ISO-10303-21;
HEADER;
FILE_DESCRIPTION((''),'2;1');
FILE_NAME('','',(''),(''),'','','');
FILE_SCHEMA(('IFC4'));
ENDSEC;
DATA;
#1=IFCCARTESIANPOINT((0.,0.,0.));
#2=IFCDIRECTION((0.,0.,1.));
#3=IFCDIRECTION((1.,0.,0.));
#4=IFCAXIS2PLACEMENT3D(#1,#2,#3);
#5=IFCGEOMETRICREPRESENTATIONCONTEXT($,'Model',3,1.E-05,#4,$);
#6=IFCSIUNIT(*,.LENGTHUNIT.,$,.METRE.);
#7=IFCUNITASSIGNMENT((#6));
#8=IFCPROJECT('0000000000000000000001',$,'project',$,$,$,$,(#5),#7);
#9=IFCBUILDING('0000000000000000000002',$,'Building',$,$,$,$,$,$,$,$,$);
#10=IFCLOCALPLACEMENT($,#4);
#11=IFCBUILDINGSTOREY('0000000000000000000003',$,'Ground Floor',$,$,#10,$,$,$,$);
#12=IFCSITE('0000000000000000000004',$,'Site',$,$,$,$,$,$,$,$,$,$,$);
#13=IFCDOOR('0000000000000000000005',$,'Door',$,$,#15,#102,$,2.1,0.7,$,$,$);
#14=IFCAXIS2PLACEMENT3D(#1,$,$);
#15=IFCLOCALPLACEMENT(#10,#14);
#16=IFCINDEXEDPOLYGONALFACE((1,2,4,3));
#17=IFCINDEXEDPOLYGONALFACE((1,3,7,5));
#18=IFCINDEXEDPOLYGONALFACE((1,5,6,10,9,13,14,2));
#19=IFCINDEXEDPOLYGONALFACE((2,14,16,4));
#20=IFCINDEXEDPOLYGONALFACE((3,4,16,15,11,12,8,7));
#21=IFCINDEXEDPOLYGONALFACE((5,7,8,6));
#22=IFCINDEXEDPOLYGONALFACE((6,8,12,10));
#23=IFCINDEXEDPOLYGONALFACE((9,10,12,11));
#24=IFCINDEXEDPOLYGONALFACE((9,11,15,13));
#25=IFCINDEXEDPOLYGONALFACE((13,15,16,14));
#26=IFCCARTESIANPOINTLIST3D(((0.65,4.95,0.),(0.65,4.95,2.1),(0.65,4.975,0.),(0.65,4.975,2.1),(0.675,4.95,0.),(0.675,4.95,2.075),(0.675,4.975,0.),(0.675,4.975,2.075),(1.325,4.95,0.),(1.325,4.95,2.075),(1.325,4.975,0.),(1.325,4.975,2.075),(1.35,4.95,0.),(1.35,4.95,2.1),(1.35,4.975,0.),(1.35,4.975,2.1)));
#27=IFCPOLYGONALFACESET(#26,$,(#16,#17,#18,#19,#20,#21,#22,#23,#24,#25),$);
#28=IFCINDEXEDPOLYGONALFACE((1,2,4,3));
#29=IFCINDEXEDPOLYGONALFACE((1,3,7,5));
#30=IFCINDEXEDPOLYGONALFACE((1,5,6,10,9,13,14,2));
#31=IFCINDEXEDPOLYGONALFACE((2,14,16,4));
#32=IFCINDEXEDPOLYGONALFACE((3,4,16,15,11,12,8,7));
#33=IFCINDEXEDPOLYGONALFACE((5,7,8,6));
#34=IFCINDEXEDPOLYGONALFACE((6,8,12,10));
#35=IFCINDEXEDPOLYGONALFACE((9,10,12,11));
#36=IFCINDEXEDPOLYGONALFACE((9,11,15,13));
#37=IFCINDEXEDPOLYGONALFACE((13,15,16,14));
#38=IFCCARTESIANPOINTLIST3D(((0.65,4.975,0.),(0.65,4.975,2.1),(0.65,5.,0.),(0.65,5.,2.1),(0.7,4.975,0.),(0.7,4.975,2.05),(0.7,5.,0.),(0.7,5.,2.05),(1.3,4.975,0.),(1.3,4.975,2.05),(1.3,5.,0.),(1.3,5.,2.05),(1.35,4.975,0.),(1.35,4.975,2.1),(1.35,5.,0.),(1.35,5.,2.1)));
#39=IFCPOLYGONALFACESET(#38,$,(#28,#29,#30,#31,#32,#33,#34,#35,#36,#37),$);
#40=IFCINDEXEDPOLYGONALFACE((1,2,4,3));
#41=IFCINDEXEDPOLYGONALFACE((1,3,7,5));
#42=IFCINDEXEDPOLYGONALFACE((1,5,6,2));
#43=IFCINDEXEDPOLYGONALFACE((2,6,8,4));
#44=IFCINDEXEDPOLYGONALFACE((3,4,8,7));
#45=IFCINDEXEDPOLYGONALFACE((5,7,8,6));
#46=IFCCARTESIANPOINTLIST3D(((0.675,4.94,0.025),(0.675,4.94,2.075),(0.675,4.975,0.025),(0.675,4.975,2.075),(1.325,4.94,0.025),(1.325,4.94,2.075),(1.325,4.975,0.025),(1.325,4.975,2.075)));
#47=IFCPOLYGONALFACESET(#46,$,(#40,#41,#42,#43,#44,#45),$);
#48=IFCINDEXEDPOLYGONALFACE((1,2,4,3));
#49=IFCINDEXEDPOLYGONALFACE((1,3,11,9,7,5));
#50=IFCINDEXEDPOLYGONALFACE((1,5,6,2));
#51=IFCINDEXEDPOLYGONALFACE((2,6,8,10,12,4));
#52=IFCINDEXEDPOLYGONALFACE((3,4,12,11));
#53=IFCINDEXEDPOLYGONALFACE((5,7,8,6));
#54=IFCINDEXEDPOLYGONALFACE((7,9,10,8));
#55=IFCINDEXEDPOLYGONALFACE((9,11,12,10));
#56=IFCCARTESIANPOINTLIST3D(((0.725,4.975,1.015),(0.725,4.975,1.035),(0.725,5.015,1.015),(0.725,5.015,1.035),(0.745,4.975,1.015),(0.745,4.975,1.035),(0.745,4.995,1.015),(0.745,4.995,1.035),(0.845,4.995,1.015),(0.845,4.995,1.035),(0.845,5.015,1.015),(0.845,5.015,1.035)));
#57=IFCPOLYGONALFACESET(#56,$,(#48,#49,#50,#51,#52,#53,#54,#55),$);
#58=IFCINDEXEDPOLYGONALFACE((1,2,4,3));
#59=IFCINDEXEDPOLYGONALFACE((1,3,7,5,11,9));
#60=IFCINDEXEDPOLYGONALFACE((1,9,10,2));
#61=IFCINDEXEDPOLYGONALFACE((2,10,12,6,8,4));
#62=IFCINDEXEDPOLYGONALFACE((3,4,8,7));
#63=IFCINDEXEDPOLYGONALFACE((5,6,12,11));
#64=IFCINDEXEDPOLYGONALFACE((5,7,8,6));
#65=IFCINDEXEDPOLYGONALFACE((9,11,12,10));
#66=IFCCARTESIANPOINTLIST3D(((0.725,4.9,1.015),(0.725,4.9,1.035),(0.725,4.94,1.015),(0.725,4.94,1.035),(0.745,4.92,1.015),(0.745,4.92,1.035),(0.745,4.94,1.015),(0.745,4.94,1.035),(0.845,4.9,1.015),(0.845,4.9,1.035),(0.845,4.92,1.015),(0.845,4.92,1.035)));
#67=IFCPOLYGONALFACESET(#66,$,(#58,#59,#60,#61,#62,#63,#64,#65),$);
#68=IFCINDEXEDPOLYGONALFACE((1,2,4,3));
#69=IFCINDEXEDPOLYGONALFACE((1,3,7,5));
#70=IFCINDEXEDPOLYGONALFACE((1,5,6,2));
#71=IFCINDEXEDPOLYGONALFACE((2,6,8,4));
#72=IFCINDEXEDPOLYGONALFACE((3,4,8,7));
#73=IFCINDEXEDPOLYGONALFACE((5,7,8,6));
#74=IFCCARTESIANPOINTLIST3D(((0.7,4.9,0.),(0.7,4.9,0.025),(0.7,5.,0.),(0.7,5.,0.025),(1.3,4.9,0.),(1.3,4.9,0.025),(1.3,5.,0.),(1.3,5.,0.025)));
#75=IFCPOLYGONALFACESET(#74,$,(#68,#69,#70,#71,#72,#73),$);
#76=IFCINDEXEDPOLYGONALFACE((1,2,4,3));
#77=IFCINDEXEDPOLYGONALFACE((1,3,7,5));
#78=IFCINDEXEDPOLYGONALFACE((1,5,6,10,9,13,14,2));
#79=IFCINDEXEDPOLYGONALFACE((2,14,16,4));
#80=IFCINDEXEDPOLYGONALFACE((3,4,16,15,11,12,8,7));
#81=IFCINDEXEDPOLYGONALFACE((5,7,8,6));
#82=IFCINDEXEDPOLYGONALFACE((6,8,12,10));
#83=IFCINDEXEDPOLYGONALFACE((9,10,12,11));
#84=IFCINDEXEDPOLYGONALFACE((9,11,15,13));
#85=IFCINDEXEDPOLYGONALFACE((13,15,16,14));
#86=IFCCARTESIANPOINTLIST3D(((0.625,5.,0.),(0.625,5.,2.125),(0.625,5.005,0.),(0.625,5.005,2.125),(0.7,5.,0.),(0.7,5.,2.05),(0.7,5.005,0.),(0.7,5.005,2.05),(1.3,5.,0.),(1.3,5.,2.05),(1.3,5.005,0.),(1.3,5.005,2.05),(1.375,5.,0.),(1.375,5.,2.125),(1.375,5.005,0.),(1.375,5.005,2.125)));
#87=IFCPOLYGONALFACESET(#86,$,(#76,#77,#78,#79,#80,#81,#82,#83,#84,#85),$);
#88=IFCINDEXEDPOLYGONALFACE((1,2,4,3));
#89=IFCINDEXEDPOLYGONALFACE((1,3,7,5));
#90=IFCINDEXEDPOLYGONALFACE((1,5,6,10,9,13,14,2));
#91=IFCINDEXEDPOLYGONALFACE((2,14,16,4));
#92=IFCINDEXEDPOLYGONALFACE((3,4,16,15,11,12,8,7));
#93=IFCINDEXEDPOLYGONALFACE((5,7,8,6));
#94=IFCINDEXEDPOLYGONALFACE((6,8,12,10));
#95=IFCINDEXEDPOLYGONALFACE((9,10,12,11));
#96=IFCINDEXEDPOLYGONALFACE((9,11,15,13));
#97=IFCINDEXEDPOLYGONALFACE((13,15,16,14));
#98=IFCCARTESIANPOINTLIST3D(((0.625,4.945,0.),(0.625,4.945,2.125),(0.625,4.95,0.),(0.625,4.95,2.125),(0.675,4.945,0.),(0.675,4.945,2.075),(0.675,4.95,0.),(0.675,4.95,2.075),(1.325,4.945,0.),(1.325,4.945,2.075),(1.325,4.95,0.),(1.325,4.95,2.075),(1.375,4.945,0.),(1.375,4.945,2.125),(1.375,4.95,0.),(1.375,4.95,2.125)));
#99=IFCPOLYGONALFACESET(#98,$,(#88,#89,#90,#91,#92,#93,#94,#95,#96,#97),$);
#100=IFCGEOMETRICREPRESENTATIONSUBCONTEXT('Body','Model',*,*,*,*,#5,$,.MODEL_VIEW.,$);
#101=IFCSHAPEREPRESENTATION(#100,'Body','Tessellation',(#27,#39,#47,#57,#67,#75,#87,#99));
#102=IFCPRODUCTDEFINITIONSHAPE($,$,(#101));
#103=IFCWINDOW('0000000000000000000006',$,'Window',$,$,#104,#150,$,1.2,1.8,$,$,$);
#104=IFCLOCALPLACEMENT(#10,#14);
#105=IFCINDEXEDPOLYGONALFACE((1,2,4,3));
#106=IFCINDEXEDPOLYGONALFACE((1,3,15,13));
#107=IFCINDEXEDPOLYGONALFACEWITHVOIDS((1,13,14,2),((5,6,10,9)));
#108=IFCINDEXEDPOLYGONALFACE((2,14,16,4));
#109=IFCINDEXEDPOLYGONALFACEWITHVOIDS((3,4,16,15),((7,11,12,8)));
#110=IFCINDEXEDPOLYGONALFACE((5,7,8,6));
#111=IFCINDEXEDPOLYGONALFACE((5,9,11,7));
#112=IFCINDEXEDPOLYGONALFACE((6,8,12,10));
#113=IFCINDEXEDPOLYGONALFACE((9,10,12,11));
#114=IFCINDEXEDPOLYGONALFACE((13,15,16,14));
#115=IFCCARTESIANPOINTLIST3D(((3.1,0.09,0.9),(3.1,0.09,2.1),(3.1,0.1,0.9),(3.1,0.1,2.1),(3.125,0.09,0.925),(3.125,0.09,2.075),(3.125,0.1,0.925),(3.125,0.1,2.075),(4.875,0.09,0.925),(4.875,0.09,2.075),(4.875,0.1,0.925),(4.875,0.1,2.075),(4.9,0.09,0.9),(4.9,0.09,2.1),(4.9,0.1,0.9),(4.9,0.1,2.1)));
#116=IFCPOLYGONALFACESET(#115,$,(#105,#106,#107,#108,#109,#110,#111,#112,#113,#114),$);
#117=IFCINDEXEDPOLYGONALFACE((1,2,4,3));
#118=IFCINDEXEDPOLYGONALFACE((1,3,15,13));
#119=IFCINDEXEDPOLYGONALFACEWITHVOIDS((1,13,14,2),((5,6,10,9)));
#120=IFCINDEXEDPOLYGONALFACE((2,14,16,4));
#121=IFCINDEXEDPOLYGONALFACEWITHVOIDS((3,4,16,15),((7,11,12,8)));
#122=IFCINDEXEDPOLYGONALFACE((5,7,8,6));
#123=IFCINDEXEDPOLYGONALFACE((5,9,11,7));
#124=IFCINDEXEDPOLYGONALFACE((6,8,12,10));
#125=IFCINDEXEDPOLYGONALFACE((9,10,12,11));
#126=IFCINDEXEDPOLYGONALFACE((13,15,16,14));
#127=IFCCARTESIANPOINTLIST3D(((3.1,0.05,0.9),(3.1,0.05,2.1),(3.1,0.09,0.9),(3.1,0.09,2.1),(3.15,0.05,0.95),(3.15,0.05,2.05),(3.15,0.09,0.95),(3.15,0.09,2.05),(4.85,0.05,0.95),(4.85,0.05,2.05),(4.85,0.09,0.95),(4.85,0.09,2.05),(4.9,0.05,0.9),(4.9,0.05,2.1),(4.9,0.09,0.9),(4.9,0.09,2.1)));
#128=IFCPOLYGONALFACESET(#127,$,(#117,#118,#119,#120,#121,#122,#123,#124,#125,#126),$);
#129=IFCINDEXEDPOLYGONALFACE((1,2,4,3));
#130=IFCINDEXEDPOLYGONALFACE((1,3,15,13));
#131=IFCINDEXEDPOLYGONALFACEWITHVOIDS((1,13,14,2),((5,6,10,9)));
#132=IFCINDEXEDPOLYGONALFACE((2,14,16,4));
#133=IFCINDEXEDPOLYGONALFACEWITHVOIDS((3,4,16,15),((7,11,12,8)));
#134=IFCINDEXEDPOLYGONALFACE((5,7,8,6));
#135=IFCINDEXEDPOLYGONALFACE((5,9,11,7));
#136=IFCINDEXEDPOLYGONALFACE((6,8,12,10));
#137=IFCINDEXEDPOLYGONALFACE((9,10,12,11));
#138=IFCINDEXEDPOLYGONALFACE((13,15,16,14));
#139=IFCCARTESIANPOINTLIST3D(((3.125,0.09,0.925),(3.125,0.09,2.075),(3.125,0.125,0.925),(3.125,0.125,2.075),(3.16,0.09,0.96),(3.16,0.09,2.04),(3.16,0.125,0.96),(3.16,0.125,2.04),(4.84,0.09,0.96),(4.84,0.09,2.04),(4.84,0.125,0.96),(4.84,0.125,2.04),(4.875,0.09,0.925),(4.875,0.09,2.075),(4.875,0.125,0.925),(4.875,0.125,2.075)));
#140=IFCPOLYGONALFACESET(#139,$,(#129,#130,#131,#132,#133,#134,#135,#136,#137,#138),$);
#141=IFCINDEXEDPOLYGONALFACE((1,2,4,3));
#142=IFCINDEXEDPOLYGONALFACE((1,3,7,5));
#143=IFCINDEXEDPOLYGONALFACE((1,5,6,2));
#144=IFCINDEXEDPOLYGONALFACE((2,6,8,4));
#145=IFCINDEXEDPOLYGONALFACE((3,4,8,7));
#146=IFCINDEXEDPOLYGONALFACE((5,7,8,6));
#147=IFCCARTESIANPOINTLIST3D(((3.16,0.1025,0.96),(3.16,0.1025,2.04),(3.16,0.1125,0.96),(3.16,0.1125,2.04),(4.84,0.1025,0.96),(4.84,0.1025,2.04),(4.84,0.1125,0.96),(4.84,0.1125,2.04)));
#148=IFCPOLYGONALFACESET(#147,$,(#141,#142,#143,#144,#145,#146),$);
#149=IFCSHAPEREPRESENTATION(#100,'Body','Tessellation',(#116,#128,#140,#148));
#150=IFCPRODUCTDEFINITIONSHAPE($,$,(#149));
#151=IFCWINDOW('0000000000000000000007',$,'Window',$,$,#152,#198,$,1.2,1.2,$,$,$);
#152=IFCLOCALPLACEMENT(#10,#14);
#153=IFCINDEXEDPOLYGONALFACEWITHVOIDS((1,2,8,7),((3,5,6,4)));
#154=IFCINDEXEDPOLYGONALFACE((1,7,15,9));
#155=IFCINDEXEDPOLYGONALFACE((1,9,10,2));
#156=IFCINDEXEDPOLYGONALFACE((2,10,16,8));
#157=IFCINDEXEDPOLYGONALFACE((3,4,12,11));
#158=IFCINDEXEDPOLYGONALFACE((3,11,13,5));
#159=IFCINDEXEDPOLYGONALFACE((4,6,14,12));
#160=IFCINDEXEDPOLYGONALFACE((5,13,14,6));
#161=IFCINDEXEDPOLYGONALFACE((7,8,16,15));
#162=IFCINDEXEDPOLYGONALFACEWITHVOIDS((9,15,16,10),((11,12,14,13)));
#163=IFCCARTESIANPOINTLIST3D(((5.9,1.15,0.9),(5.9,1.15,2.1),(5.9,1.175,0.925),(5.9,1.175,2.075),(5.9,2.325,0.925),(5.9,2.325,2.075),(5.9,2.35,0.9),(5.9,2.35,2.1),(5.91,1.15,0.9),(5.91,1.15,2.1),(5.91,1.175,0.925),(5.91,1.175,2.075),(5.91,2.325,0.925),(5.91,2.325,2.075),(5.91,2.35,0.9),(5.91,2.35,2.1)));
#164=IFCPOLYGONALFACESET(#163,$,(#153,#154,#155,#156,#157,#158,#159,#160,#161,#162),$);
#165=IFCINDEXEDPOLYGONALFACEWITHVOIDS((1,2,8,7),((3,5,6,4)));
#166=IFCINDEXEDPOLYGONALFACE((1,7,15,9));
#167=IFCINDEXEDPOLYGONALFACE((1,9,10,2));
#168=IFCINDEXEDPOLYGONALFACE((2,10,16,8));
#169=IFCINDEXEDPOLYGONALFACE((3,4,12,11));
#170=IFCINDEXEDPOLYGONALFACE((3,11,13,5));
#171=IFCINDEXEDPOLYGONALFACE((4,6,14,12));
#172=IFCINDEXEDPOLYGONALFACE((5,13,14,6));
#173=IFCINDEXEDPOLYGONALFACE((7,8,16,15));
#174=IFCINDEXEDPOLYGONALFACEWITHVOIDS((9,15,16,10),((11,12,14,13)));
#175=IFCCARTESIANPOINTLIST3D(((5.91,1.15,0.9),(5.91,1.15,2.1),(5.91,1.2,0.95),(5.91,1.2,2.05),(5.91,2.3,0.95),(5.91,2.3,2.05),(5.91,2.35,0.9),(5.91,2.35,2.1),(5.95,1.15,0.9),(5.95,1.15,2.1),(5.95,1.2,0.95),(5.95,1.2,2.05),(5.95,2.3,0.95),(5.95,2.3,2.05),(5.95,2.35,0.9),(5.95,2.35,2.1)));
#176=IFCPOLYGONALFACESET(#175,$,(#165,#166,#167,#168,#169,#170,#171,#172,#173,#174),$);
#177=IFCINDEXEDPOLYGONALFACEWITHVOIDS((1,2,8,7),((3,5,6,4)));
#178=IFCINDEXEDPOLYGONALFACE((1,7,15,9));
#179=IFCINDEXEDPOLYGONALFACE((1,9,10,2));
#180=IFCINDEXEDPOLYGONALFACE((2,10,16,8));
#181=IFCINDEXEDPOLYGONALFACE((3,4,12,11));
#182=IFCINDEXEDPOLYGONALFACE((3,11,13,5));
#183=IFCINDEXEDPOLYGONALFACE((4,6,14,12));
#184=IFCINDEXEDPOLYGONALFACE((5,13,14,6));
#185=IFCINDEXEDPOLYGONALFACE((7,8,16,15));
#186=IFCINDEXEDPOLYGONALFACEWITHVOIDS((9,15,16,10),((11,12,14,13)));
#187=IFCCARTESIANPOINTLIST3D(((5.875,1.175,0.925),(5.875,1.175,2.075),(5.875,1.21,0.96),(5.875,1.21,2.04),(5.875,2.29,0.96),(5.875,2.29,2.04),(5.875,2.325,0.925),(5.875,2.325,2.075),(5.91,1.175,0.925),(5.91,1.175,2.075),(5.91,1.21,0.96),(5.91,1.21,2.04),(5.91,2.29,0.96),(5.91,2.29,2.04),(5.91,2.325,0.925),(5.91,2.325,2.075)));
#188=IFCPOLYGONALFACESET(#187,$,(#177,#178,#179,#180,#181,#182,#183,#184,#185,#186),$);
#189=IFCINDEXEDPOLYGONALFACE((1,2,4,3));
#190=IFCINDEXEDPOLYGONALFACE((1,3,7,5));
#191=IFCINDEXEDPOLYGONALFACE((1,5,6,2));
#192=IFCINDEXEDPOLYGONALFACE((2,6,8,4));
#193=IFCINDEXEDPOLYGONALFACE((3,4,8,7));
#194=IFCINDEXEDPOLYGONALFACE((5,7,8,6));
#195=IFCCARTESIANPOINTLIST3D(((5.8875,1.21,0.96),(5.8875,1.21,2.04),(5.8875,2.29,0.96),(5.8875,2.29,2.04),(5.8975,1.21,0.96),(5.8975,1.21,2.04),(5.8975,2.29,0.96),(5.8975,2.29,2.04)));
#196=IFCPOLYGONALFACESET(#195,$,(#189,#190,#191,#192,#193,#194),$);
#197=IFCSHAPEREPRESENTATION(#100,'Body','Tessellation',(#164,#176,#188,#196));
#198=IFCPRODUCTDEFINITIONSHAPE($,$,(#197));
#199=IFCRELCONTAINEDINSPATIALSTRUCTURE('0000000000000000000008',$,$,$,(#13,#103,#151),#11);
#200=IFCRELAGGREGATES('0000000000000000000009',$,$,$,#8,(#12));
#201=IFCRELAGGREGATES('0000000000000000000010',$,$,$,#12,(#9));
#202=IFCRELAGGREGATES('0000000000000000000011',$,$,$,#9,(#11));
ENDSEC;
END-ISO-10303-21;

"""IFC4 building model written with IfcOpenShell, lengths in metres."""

from ifc_helpers import new_model, si_unit, frame, origin_with_axes, place, context, subcontext, project, spatial, line, indexed_curve, outline, extrude, element, save


model = new_model("IFC4")

# Units and contexts
model_context = context("Model", 3, precision=1e-05, world=origin_with_axes())
body_context = subcontext(model_context, "Body", "Model", "MODEL_VIEW")
ifc_project = project(units=[si_unit("LENGTHUNIT", "METRE")], contexts=[model_context])

# Site, building, storey
site = spatial("IfcSite", under=ifc_project, Name="Site")
building = spatial("IfcBuilding", under=site, Name="Building")
storey_placement = place(None, origin_with_axes())
storey = spatial("IfcBuildingStorey", under=building, at=storey_placement, Name="Ground Floor")

# Door
door_1_placement = place(storey_placement, frame((1.35, 5.0, 0.0), z_axis=(0.0, 0.0, 1.0), x_axis=(-1.0, 0.0, 0.0)))
element("IfcDoor", 1, at=door_1_placement, inside=storey, Name="Door", OverallHeight=2.1, OverallWidth=0.7, context=body_context, shape_type="SweptSolid", body=[
    extrude(outline(indexed_curve([(0.0, 0.0), (0.0, 2.1), (0.7, 2.1), (0.7, 0.0), (0.675, 0.0), (0.675, 2.075), (0.025, 2.075), (0.025, 0.0)], segments=[line(1, 2, 3, 4, 5, 6, 7, 8, 1)])), frame((0.0, 0.025, 0.0), z_axis=(0.0, -1.0, 0.0), x_axis=(1.0, 0.0, 0.0)), (0.0, 0.0, -1.0), 0.025),
    extrude(outline(indexed_curve([(0.0, 0.0), (0.0, 2.1), (0.7, 2.1), (0.7, 0.0), (0.65, 0.0), (0.65, 2.05), (0.05, 2.05), (0.05, 0.0)], segments=[line(1, 2, 3, 4, 5, 6, 7, 8, 1)])), frame((0.0, 0.0, 0.0), z_axis=(0.0, -1.0, 0.0), x_axis=(1.0, 0.0, 0.0)), (0.0, 0.0, -1.0), 0.025),
    extrude(outline(indexed_curve([(0.0, 0.0), (0.65, 0.0), (0.65, 0.035), (0.0, 0.035)], segments=[line(1, 2, 3, 4, 1)])), frame((0.025, 0.025, 0.025), z_axis=(0.0, 0.0, 1.0), x_axis=(1.0, 0.0, 0.0)), (0.0, 0.0, 1.0), 2.05),
    extrude(outline(indexed_curve([(0.0, 0.0), (0.0, -0.04), (-0.12, -0.04), (-0.12, -0.02), (-0.02, -0.02), (-0.02, 0.0)], segments=[line(1, 2, 3, 4, 5, 6, 1)])), frame((0.625, 0.025, 1.015), z_axis=(0.0, 0.0, 1.0), x_axis=(1.0, 0.0, 0.0)), (0.0, 0.0, 1.0), 0.02),
    extrude(outline(indexed_curve([(0.0, 0.0), (0.0, 0.04), (-0.12, 0.04), (-0.12, 0.02), (-0.02, 0.02), (-0.02, 0.0)], segments=[line(1, 2, 3, 4, 5, 6, 1)])), frame((0.625, 0.06, 1.015), z_axis=(0.0, 0.0, 1.0), x_axis=(1.0, 0.0, 0.0)), (0.0, 0.0, 1.0), 0.02),
    extrude(outline(indexed_curve([(0.0, 0.0), (0.6, 0.0), (0.6, 0.1), (0.0, 0.1)], segments=[line(1, 2, 3, 4, 1)])), frame((0.05, 0.0, 0.0), z_axis=(0.0, 0.0, 1.0), x_axis=(1.0, 0.0, 0.0)), (0.0, 0.0, 1.0), 0.025),
    extrude(outline(indexed_curve([(0.0, 0.0), (0.0, 2.125), (0.75, 2.125), (0.75, 0.0), (0.675, 0.0), (0.675, 2.05), (0.075, 2.05), (0.075, 0.0)], segments=[line(1, 2, 3, 4, 5, 6, 7, 8, 1)])), frame((-0.025, -0.005, 0.0), z_axis=(0.0, -1.0, 0.0), x_axis=(1.0, 0.0, 0.0)), (0.0, 0.0, -1.0), 0.005),
    extrude(outline(indexed_curve([(0.0, 0.0), (0.0, 2.125), (0.75, 2.125), (0.75, 0.0), (0.7, 0.0), (0.7, 2.075), (0.05, 2.075), (0.05, 0.0)], segments=[line(1, 2, 3, 4, 5, 6, 7, 8, 1)])), frame((-0.025, 0.05, 0.0), z_axis=(0.0, -1.0, 0.0), x_axis=(1.0, 0.0, 0.0)), (0.0, 0.0, -1.0), 0.005),
])

# Windows
window_1_placement = place(storey_placement, frame((3.1, 0.0, 0.9), z_axis=(0.0, 0.0, 1.0), x_axis=(1.0, 0.0, 0.0)))
element("IfcWindow", 2, at=window_1_placement, inside=storey, Name="Window", OverallHeight=1.2, OverallWidth=1.8, context=body_context, shape_type="SweptSolid", body=[
    extrude(outline(indexed_curve([(0.0, 0.0), (1.8, 0.0), (1.8, 1.2), (0.0, 1.2)], segments=[line(1, 2, 3, 4, 1)]), holes=[indexed_curve([(0.025, 0.025), (1.775, 0.025), (1.775, 1.175), (0.025, 1.175)], segments=[line(1, 2, 3, 4, 1)])]), frame((0.0, 0.09, 0.0), z_axis=(0.0, -1.0, 0.0), x_axis=(1.0, 0.0, 0.0)), (0.0, 0.0, -1.0), 0.01),
    extrude(outline(indexed_curve([(0.0, 0.0), (1.8, 0.0), (1.8, 1.2), (0.0, 1.2)], segments=[line(1, 2, 3, 4, 1)]), holes=[indexed_curve([(0.05, 0.05), (1.75, 0.05), (1.75, 1.15), (0.05, 1.15)], segments=[line(1, 2, 3, 4, 1)])]), frame((0.0, 0.05, 0.0), z_axis=(0.0, -1.0, 0.0), x_axis=(1.0, 0.0, 0.0)), (0.0, 0.0, -1.0), 0.04),
    extrude(outline(indexed_curve([(0.0, 0.0), (1.75, 0.0), (1.75, 1.15), (0.0, 1.15)], segments=[line(1, 2, 3, 4, 1)]), holes=[indexed_curve([(0.035, 0.035), (1.715, 0.035), (1.715, 1.115), (0.035, 1.115)], segments=[line(1, 2, 3, 4, 1)])]), frame((0.025, 0.09, 0.025), z_axis=(0.0, -1.0, 0.0), x_axis=(1.0, 0.0, 0.0)), (0.0, 0.0, -1.0), 0.035),
    extrude(outline(indexed_curve([(0.035, 0.035), (1.715, 0.035), (1.715, 1.115), (0.035, 1.115)], segments=[line(1, 2, 3, 4, 1)])), frame((0.025, 0.1025, 0.025), z_axis=(0.0, -1.0, 0.0), x_axis=(1.0, 0.0, 0.0)), (0.0, 0.0, -1.0), 0.01),
])
window_2_placement = place(storey_placement, frame((6.0, 1.15, 0.9), z_axis=(0.0, 0.0, 1.0), x_axis=(0.0, 1.0, 0.0)))
element("IfcWindow", 3, at=window_2_placement, inside=storey, Name="Window", OverallHeight=1.2, OverallWidth=1.2, context=body_context, shape_type="SweptSolid", body=[
    extrude(outline(indexed_curve([(0.0, 0.0), (1.2, 0.0), (1.2, 1.2), (0.0, 1.2)], segments=[line(1, 2, 3, 4, 1)]), holes=[indexed_curve([(0.025, 0.025), (1.175, 0.025), (1.175, 1.175), (0.025, 1.175)], segments=[line(1, 2, 3, 4, 1)])]), frame((0.0, 0.09, 0.0), z_axis=(0.0, -1.0, 0.0), x_axis=(1.0, 0.0, 0.0)), (0.0, 0.0, -1.0), 0.01),
    extrude(outline(indexed_curve([(0.0, 0.0), (1.2, 0.0), (1.2, 1.2), (0.0, 1.2)], segments=[line(1, 2, 3, 4, 1)]), holes=[indexed_curve([(0.05, 0.05), (1.15, 0.05), (1.15, 1.15), (0.05, 1.15)], segments=[line(1, 2, 3, 4, 1)])]), frame((0.0, 0.05, 0.0), z_axis=(0.0, -1.0, 0.0), x_axis=(1.0, 0.0, 0.0)), (0.0, 0.0, -1.0), 0.04),
    extrude(outline(indexed_curve([(0.0, 0.0), (1.15, 0.0), (1.15, 1.15), (0.0, 1.15)], segments=[line(1, 2, 3, 4, 1)]), holes=[indexed_curve([(0.035, 0.035), (1.115, 0.035), (1.115, 1.115), (0.035, 1.115)], segments=[line(1, 2, 3, 4, 1)])]), frame((0.025, 0.09, 0.025), z_axis=(0.0, -1.0, 0.0), x_axis=(1.0, 0.0, 0.0)), (0.0, 0.0, -1.0), 0.035),
    extrude(outline(indexed_curve([(0.035, 0.035), (1.115, 0.035), (1.115, 1.115), (0.035, 1.115)], segments=[line(1, 2, 3, 4, 1)])), frame((0.025, 0.1025, 0.025), z_axis=(0.0, -1.0, 0.0), x_axis=(1.0, 0.0, 0.0)), (0.0, 0.0, -1.0), 0.01),
])

save(model, "model.ifc")
